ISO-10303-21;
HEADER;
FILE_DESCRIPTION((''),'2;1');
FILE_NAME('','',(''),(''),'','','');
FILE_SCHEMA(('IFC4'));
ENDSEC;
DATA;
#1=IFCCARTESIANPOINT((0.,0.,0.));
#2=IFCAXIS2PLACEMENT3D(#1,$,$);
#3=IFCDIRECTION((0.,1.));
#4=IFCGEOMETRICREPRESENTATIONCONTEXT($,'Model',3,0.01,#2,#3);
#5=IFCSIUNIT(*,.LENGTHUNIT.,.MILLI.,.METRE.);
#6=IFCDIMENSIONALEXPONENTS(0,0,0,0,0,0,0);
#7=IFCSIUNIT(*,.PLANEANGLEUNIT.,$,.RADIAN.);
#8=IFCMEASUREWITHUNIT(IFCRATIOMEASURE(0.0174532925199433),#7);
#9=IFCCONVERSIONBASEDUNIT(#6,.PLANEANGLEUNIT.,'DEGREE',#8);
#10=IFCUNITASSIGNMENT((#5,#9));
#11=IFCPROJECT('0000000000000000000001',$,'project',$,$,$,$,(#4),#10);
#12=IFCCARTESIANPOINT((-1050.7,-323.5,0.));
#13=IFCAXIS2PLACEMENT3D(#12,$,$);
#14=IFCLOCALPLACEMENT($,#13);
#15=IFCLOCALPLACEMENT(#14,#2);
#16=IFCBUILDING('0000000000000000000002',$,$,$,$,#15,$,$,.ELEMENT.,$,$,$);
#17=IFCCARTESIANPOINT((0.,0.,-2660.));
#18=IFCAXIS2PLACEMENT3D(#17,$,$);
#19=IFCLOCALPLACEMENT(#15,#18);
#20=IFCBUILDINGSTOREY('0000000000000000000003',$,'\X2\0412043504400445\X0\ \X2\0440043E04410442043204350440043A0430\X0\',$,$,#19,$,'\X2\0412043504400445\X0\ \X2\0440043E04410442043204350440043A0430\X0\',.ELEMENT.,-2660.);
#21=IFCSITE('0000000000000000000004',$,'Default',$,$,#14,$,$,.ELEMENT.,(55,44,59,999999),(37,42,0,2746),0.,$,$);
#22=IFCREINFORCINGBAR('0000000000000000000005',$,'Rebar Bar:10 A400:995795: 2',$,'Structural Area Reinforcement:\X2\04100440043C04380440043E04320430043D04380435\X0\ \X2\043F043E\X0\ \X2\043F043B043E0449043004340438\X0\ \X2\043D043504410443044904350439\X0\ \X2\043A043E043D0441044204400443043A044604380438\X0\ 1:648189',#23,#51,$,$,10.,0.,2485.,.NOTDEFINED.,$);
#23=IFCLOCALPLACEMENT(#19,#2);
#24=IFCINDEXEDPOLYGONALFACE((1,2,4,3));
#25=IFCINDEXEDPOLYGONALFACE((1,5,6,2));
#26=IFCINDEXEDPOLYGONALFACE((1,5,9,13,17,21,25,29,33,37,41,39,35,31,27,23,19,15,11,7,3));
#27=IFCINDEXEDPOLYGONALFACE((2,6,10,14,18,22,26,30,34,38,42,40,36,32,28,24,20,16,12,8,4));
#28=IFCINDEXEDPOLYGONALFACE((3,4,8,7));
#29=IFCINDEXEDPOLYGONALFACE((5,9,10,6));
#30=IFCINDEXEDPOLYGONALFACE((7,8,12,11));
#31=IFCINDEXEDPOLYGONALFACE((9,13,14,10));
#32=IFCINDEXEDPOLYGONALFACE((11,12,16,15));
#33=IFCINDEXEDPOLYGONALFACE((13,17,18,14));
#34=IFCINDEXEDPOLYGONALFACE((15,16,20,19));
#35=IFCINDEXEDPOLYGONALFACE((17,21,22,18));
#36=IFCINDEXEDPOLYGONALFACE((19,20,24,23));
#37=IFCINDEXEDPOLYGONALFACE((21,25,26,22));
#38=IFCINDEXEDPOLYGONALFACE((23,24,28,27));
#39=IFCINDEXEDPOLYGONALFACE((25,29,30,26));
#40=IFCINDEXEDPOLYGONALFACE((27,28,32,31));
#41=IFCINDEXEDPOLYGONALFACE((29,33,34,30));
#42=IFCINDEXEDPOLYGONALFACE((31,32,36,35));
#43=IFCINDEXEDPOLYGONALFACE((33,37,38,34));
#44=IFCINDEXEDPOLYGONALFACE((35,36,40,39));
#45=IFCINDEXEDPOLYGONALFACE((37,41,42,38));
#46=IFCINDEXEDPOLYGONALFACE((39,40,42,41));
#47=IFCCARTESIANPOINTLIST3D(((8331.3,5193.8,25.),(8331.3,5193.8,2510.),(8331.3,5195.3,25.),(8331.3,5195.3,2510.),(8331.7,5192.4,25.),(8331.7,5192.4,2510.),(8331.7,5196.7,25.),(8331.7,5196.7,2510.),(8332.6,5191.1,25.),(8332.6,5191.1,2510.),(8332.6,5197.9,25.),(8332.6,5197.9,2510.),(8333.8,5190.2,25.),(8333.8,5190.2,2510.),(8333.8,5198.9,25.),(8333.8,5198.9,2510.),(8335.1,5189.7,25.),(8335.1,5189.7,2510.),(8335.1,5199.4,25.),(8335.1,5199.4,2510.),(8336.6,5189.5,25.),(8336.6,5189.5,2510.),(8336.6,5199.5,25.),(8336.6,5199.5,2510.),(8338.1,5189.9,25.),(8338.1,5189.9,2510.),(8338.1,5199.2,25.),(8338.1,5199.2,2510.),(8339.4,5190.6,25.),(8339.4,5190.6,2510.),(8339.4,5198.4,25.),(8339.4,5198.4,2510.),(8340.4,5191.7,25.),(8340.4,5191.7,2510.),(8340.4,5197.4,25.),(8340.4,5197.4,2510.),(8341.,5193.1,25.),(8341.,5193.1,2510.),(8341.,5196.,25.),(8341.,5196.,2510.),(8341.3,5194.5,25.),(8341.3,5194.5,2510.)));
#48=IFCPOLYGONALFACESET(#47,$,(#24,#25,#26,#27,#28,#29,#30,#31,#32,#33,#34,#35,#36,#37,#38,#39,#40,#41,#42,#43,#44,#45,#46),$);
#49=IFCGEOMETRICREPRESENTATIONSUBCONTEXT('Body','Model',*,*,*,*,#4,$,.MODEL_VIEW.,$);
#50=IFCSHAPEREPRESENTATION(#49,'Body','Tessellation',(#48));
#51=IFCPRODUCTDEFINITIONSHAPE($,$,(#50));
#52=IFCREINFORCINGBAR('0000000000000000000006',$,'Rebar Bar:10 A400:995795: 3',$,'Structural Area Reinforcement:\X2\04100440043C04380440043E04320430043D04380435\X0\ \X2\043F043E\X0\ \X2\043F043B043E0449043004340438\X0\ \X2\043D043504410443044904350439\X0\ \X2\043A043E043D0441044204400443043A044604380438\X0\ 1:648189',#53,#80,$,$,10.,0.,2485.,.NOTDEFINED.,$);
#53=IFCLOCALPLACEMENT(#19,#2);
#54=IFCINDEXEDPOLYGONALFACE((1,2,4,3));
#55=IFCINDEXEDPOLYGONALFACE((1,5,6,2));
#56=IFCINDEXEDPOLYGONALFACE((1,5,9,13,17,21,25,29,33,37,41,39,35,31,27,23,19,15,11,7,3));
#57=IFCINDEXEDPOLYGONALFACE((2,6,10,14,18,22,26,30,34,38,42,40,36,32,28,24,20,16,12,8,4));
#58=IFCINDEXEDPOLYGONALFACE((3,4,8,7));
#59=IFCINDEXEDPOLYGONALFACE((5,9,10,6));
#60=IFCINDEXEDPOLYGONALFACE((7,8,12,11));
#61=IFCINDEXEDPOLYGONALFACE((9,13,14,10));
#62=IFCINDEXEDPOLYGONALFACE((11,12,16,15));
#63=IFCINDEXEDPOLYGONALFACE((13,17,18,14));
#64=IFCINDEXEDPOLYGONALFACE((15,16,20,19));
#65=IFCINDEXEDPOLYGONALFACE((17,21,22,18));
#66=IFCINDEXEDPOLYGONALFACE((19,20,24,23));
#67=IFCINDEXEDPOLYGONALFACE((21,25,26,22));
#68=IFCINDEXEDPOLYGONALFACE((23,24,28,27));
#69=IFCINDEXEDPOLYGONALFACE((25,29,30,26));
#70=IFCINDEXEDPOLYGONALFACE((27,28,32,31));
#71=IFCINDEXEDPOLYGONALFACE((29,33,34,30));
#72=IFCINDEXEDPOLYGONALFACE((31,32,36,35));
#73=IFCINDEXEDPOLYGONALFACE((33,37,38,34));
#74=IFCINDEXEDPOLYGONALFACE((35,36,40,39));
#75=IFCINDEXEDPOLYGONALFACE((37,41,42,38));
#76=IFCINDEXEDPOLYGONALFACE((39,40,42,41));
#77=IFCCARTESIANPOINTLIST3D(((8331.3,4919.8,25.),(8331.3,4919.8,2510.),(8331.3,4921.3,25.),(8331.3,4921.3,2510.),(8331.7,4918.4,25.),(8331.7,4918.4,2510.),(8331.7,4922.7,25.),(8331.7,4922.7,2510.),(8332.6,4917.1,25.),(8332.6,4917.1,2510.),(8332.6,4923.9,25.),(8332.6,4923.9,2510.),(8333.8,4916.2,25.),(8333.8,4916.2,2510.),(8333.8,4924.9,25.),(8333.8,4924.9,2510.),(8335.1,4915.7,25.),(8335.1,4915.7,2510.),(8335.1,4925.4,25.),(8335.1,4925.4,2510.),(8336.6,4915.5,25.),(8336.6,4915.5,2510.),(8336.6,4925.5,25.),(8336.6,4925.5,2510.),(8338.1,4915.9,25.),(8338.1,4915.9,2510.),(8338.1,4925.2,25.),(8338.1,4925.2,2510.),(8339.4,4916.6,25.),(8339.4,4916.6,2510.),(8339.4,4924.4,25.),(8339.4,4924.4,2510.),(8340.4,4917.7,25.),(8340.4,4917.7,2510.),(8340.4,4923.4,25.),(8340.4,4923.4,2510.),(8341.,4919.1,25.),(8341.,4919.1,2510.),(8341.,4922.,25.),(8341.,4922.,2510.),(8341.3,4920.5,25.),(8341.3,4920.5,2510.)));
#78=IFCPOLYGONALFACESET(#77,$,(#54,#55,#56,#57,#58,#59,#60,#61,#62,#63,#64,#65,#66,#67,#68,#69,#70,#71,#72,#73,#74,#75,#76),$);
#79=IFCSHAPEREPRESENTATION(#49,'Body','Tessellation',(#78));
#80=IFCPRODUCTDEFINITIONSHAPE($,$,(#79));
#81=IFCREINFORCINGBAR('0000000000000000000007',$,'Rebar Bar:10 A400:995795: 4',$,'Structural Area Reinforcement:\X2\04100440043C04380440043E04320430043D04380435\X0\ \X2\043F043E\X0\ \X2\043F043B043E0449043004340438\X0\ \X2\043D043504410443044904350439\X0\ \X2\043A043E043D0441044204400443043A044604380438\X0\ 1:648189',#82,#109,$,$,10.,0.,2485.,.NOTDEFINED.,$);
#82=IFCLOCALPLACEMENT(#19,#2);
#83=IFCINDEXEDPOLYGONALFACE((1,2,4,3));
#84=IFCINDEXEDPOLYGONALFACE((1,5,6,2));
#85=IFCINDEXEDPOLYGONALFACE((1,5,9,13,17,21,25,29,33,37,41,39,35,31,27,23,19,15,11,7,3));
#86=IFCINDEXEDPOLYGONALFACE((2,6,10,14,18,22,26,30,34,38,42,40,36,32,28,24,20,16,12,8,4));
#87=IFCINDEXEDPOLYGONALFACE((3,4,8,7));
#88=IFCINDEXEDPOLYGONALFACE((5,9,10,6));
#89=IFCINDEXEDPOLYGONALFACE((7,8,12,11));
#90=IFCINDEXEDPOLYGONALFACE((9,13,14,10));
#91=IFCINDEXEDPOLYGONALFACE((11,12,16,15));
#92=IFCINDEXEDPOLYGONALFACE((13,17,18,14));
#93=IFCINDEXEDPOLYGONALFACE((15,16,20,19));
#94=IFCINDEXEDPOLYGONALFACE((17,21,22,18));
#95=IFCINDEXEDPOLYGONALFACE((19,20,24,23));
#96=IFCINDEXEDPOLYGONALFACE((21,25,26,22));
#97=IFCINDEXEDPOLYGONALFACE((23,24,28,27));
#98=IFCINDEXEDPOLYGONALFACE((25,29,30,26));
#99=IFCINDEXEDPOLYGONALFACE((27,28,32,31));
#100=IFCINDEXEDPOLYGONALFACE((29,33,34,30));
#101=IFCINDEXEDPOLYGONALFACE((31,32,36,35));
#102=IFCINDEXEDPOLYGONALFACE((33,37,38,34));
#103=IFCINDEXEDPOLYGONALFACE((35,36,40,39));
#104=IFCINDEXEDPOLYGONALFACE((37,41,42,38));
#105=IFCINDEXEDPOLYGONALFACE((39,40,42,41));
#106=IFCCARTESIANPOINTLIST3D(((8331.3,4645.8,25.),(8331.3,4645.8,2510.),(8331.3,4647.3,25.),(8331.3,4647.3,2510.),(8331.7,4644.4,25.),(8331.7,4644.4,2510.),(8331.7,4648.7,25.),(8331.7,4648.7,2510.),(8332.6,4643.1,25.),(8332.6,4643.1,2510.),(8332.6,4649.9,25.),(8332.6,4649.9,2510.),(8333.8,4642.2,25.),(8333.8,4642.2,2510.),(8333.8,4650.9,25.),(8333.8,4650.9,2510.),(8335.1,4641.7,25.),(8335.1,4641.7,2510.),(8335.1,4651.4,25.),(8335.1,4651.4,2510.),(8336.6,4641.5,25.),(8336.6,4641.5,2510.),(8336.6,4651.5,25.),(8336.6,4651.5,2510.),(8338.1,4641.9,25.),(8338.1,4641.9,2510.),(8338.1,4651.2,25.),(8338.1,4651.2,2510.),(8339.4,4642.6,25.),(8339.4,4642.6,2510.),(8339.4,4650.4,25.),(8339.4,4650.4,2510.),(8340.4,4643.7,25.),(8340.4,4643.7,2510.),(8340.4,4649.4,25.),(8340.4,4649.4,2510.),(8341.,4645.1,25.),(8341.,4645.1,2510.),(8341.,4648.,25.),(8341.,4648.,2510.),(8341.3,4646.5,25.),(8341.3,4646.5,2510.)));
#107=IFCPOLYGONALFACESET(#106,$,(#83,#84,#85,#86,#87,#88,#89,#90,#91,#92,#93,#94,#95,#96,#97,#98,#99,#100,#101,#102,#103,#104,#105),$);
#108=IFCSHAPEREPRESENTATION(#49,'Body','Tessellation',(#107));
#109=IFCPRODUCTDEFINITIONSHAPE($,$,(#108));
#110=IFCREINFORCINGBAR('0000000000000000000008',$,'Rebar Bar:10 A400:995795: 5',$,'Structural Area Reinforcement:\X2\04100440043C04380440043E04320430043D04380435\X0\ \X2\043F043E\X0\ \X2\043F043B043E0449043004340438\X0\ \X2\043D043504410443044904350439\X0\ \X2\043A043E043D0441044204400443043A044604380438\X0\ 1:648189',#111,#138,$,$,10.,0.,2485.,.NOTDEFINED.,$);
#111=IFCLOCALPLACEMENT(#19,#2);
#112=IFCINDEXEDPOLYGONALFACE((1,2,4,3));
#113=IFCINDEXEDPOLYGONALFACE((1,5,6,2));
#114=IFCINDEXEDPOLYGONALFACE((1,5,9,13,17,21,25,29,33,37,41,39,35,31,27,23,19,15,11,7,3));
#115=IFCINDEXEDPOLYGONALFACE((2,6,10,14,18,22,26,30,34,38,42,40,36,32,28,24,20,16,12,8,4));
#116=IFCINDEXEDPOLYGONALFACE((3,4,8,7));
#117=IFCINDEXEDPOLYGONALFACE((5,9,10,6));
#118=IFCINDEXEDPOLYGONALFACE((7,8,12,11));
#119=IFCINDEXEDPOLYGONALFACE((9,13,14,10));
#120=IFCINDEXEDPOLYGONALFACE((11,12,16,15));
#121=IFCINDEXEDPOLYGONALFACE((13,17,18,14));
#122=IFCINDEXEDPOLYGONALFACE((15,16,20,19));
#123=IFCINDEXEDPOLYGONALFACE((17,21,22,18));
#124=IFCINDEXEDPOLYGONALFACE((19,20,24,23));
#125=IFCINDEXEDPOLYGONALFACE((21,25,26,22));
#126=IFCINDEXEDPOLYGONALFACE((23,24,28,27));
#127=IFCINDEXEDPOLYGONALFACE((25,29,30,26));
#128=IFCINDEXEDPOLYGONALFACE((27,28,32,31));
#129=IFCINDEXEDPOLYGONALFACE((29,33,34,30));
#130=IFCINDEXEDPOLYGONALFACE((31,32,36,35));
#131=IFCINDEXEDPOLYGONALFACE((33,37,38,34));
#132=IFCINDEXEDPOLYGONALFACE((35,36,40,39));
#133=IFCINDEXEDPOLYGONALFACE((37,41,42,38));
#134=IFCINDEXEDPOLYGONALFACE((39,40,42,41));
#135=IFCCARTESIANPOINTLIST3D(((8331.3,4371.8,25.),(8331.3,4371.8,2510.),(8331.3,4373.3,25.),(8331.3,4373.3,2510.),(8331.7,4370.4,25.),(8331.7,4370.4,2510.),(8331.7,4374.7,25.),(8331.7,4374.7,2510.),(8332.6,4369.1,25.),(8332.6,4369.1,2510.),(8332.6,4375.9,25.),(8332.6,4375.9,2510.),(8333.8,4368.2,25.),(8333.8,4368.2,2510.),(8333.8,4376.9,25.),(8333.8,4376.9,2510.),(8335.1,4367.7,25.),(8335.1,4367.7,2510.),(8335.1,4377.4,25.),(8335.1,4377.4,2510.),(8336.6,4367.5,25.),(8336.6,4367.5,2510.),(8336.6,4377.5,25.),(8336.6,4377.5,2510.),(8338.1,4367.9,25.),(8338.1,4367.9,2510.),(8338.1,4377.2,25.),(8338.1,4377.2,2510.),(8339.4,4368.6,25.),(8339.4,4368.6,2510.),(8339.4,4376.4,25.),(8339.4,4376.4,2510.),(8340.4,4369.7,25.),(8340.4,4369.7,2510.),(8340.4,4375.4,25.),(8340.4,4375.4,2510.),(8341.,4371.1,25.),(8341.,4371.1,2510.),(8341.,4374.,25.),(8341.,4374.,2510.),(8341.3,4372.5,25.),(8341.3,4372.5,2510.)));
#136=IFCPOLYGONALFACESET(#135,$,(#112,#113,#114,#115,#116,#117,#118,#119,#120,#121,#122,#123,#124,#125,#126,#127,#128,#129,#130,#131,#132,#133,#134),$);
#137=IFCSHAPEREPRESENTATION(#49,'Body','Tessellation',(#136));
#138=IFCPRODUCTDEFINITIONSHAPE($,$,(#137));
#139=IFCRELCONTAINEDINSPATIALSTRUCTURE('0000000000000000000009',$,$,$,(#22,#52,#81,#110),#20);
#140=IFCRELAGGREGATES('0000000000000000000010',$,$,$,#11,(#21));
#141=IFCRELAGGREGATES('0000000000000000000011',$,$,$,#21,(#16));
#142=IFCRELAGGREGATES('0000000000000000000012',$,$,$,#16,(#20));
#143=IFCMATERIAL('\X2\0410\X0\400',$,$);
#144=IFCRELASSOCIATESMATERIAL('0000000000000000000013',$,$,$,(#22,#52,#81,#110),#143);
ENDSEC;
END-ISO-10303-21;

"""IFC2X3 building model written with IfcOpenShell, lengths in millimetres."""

from ifc_helpers import new_model, entity, si_unit, converted_unit, direction, frame, origin, place, context, subcontext, project, spatial, material, element, save


model = new_model("IFC2X3")

# Units and contexts
model_context = context("Model", 3, precision=0.01, world=origin(), true_north=direction((0.0, 1.0)))
body_context = subcontext(model_context, "Body", "Model", "MODEL_VIEW")
ifc_project = project(units=[si_unit("LENGTHUNIT", "METRE", prefix="MILLI"), converted_unit("PLANEANGLEUNIT", "DEGREE", entity("IfcRatioMeasure", 0.0174532925199433), si_unit("PLANEANGLEUNIT", "RADIAN"), dimensions=[0, 0, 0, 0, 0, 0, 0])], contexts=[model_context])

# Site, building, storey
site_placement = place(None, frame((-1050.7, -323.5, 0.0)))
site = spatial("IfcSite", under=ifc_project, at=site_placement, Name="Default", CompositionType="ELEMENT", RefLatitude=(55, 44, 59, 999999), RefLongitude=(37, 42, 0, 2746), RefElevation=0.0)
building_placement = place(site_placement, origin())
building = spatial("IfcBuilding", under=site, at=building_placement, CompositionType="ELEMENT")
storey_placement = place(building_placement, frame((0.0, 0.0, -2660.0)))
storey = spatial("IfcBuildingStorey", under=building, at=storey_placement, Name="Верх ростверка", LongName="Верх ростверка", CompositionType="ELEMENT", Elevation=-2660.0)

# Reinforcing bars
ifc_material = material(Name="А400")
reinforcing_bar_1_placement = place(storey_placement, origin())
element("IfcReinforcingBar", 1, at=reinforcing_bar_1_placement, inside=storey, material=ifc_material, Name="Rebar Bar:10 A400:995795: 2", ObjectType="Structural Area Reinforcement:Армирование по площади несущей конструкции 1:648189", BarLength=2485.0, BarRole="NOTDEFINED", CrossSectionArea=0.0, NominalDiameter=10.0, context=body_context, shape_type="AdvancedSweptSolid", body=[
    entity("IfcSweptDiskSolid", entity("IfcCompositeCurve", [entity("IfcCompositeCurveSegment", "CONTINUOUS", True, entity("IfcPolyline", [entity("IfcCartesianPoint", [8336.3, 5194.5, 25.0]), entity("IfcCartesianPoint", [8336.3, 5194.5, 2510.0])]))], False), 5.0, None, 0.0, 1.0),
])
reinforcing_bar_2_placement = place(storey_placement, origin())
element("IfcReinforcingBar", 2, at=reinforcing_bar_2_placement, inside=storey, material=ifc_material, Name="Rebar Bar:10 A400:995795: 3", ObjectType="Structural Area Reinforcement:Армирование по площади несущей конструкции 1:648189", BarLength=2485.0, BarRole="NOTDEFINED", CrossSectionArea=0.0, NominalDiameter=10.0, context=body_context, shape_type="AdvancedSweptSolid", body=[
    entity("IfcSweptDiskSolid", entity("IfcCompositeCurve", [entity("IfcCompositeCurveSegment", "CONTINUOUS", True, entity("IfcPolyline", [entity("IfcCartesianPoint", [8336.3, 4920.5, 25.0]), entity("IfcCartesianPoint", [8336.3, 4920.5, 2510.0])]))], False), 5.0, None, 0.0, 1.0),
])
reinforcing_bar_3_placement = place(storey_placement, origin())
element("IfcReinforcingBar", 3, at=reinforcing_bar_3_placement, inside=storey, material=ifc_material, Name="Rebar Bar:10 A400:995795: 4", ObjectType="Structural Area Reinforcement:Армирование по площади несущей конструкции 1:648189", BarLength=2485.0, BarRole="NOTDEFINED", CrossSectionArea=0.0, NominalDiameter=10.0, context=body_context, shape_type="AdvancedSweptSolid", body=[
    entity("IfcSweptDiskSolid", entity("IfcCompositeCurve", [entity("IfcCompositeCurveSegment", "CONTINUOUS", True, entity("IfcPolyline", [entity("IfcCartesianPoint", [8336.3, 4646.5, 25.0]), entity("IfcCartesianPoint", [8336.3, 4646.5, 2510.0])]))], False), 5.0, None, 0.0, 1.0),
])
reinforcing_bar_4_placement = place(storey_placement, origin())
element("IfcReinforcingBar", 4, at=reinforcing_bar_4_placement, inside=storey, material=ifc_material, Name="Rebar Bar:10 A400:995795: 5", ObjectType="Structural Area Reinforcement:Армирование по площади несущей конструкции 1:648189", BarLength=2485.0, BarRole="NOTDEFINED", CrossSectionArea=0.0, NominalDiameter=10.0, context=body_context, shape_type="AdvancedSweptSolid", body=[
    entity("IfcSweptDiskSolid", entity("IfcCompositeCurve", [entity("IfcCompositeCurveSegment", "CONTINUOUS", True, entity("IfcPolyline", [entity("IfcCartesianPoint", [8336.3, 4372.5, 25.0]), entity("IfcCartesianPoint", [8336.3, 4372.5, 2510.0])]))], False), 5.0, None, 0.0, 1.0),
])

save(model, "model.ifc")
